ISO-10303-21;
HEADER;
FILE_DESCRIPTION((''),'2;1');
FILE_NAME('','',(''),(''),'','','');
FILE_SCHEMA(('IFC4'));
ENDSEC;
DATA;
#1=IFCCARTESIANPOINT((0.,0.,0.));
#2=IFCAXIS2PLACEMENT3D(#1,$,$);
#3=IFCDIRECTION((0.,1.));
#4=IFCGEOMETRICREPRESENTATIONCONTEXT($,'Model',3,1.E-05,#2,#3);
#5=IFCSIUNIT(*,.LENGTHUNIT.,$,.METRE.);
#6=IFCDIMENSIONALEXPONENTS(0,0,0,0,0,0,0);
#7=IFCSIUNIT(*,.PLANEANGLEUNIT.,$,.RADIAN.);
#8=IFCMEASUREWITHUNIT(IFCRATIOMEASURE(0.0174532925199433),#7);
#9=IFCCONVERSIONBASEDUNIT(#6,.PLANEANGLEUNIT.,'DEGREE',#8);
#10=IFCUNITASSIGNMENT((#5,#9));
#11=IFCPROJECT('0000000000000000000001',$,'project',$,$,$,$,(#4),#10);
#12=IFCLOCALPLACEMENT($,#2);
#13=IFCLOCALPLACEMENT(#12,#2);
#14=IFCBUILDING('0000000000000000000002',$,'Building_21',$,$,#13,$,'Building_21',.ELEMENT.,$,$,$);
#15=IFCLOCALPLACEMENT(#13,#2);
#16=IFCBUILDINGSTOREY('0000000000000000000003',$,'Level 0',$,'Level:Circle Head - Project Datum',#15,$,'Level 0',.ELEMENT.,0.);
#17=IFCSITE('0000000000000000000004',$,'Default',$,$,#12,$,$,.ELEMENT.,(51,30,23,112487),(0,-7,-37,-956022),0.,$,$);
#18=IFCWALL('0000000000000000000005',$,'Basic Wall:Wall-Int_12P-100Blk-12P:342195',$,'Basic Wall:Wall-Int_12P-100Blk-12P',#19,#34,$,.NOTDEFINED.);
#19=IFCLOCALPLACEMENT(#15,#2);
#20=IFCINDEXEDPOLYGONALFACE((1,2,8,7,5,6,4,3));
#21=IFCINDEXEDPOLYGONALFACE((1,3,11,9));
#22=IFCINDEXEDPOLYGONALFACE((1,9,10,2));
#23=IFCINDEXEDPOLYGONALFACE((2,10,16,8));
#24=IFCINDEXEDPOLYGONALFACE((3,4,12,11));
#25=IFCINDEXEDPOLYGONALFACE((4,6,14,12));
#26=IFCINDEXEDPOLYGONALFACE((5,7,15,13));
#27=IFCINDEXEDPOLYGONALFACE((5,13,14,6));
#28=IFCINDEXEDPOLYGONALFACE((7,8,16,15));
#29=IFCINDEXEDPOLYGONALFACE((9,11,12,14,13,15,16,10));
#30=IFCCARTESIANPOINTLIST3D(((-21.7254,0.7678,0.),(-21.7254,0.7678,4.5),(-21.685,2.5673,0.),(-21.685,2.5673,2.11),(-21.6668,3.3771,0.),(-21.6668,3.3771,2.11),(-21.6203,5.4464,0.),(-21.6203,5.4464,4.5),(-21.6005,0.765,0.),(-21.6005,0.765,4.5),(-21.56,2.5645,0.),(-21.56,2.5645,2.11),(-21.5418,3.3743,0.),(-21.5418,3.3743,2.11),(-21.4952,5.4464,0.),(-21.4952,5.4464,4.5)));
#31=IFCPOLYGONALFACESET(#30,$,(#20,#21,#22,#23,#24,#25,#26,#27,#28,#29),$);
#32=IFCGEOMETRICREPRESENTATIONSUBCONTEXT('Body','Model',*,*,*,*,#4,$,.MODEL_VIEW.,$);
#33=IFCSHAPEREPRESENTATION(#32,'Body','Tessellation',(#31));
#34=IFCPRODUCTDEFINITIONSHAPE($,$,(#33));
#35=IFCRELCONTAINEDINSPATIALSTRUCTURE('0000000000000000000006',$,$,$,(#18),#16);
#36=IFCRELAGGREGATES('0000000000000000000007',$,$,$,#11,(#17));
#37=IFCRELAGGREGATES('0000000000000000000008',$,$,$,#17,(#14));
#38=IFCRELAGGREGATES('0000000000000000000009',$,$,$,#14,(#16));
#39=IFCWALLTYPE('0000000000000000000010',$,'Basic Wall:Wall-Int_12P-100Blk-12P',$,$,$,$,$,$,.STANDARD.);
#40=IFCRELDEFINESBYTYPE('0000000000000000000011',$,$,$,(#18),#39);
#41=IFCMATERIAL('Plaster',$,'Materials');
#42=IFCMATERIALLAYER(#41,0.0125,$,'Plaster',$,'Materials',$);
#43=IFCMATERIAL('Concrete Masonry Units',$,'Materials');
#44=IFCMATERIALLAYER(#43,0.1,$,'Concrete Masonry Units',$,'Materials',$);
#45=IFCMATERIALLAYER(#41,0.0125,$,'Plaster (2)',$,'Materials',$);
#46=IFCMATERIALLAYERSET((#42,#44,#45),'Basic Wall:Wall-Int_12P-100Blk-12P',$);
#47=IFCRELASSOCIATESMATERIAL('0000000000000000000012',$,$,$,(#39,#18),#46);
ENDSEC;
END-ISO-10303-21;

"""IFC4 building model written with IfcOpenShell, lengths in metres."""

from ifc_helpers import new_model, entity, si_unit, converted_unit, direction, frame, frame_2d, origin, place, context, subcontext, project, spatial, polyline, rectangle, outline, extrude, material, layer, layer_set, layer_usage, type_object, element, save


model = new_model("IFC4")

# Units and contexts
model_context = context("Model", 3, precision=1e-05, world=origin(), true_north=direction((0.0, 1.0)))
body_context = subcontext(model_context, "Body", "Model", "MODEL_VIEW")
ifc_project = project(units=[si_unit("LENGTHUNIT", "METRE"), converted_unit("PLANEANGLEUNIT", "DEGREE", entity("IfcRatioMeasure", 0.0174532925199433), si_unit("PLANEANGLEUNIT", "RADIAN"), dimensions=[0, 0, 0, 0, 0, 0, 0])], contexts=[model_context])

# Site, building, storey
site_placement = place(None, origin())
site = spatial("IfcSite", under=ifc_project, at=site_placement, Name="Default", CompositionType="ELEMENT", RefLatitude=(51, 30, 23, 112487), RefLongitude=(0, -7, -37, -956022), RefElevation=0.0)
building_placement = place(site_placement, origin())
building = spatial("IfcBuilding", under=site, at=building_placement, Name="Building_21", LongName="Building_21", CompositionType="ELEMENT")
storey_placement = place(building_placement, origin())
storey = spatial("IfcBuildingStorey", under=building, at=storey_placement, Name="Level 0", ObjectType="Level:Circle Head - Project Datum", LongName="Level 0", CompositionType="ELEMENT", Elevation=0.0)

# Shared definitions
ifc_material_1 = material(Name="Plaster", Category="Materials")

# Wall, opening
ifc_layer_1 = layer(ifc_material_1, 0.0125, Name="Plaster", Category="Materials")
ifc_material_2 = material(Name="Concrete Masonry Units", Category="Materials")
ifc_layer_2 = layer(ifc_material_2, 0.1, Name="Concrete Masonry Units", Category="Materials")
ifc_layer_3 = layer(ifc_material_1, 0.0125, Name="Plaster (2)", Category="Materials")
ifc_layer_set_1 = layer_set([ifc_layer_1, ifc_layer_2, ifc_layer_3], Name="Basic Wall:Wall-Int_12P-100Blk-12P")
wall_type_1 = type_object("IfcWallType", Name="Basic Wall:Wall-Int_12P-100Blk-12P", PredefinedType="STANDARD", material=ifc_layer_set_1)
ifc_layer_usage_1 = layer_usage(ifc_layer_set_1, "AXIS2", "NEGATIVE", 0.0625)
wall_1_placement = place(storey_placement, frame((-21.663, 0.7664, 0.0), z_axis=(0.0, 0.0, 1.0), x_axis=(0.022471, 0.999747, 0.0)))
wall_1 = element("IfcWall", 1, at=wall_1_placement, inside=storey, type_object=wall_type_1, material=ifc_layer_usage_1, Name="Basic Wall:Wall-Int_12P-100Blk-12P:342195", ObjectType="Basic Wall:Wall-Int_12P-100Blk-12P", PredefinedType="NOTDEFINED", context=body_context, shape_type="SweptSolid", body=[
    extrude(outline(polyline([(0.0, -0.0625), (4.6826, -0.0625), (4.6798, 0.0625), (0.0, 0.0625), (0.0, -0.0625)])), origin(), (0.0, 0.0, 1.0), 4.5),
])
opening_1_placement = place(wall_1_placement, frame((1.8, -0.0625, 0.0)))
element("IfcOpeningElement", 2, at=opening_1_placement, cuts=wall_1, PredefinedType="OPENING", context=body_context, shape_type="SweptSolid", body=[
    extrude(rectangle(XDim=2.11, YDim=0.81, at=frame_2d((1.055, 0.405), x_axis=(1.0, 0.0))), frame((0.0, 0.0, 0.0), z_axis=(0.0, 1.0, 0.0), x_axis=(0.0, 0.0, 1.0)), (0.0, 0.0, 1.0), 0.125),
])

save(model, "model.ifc")
